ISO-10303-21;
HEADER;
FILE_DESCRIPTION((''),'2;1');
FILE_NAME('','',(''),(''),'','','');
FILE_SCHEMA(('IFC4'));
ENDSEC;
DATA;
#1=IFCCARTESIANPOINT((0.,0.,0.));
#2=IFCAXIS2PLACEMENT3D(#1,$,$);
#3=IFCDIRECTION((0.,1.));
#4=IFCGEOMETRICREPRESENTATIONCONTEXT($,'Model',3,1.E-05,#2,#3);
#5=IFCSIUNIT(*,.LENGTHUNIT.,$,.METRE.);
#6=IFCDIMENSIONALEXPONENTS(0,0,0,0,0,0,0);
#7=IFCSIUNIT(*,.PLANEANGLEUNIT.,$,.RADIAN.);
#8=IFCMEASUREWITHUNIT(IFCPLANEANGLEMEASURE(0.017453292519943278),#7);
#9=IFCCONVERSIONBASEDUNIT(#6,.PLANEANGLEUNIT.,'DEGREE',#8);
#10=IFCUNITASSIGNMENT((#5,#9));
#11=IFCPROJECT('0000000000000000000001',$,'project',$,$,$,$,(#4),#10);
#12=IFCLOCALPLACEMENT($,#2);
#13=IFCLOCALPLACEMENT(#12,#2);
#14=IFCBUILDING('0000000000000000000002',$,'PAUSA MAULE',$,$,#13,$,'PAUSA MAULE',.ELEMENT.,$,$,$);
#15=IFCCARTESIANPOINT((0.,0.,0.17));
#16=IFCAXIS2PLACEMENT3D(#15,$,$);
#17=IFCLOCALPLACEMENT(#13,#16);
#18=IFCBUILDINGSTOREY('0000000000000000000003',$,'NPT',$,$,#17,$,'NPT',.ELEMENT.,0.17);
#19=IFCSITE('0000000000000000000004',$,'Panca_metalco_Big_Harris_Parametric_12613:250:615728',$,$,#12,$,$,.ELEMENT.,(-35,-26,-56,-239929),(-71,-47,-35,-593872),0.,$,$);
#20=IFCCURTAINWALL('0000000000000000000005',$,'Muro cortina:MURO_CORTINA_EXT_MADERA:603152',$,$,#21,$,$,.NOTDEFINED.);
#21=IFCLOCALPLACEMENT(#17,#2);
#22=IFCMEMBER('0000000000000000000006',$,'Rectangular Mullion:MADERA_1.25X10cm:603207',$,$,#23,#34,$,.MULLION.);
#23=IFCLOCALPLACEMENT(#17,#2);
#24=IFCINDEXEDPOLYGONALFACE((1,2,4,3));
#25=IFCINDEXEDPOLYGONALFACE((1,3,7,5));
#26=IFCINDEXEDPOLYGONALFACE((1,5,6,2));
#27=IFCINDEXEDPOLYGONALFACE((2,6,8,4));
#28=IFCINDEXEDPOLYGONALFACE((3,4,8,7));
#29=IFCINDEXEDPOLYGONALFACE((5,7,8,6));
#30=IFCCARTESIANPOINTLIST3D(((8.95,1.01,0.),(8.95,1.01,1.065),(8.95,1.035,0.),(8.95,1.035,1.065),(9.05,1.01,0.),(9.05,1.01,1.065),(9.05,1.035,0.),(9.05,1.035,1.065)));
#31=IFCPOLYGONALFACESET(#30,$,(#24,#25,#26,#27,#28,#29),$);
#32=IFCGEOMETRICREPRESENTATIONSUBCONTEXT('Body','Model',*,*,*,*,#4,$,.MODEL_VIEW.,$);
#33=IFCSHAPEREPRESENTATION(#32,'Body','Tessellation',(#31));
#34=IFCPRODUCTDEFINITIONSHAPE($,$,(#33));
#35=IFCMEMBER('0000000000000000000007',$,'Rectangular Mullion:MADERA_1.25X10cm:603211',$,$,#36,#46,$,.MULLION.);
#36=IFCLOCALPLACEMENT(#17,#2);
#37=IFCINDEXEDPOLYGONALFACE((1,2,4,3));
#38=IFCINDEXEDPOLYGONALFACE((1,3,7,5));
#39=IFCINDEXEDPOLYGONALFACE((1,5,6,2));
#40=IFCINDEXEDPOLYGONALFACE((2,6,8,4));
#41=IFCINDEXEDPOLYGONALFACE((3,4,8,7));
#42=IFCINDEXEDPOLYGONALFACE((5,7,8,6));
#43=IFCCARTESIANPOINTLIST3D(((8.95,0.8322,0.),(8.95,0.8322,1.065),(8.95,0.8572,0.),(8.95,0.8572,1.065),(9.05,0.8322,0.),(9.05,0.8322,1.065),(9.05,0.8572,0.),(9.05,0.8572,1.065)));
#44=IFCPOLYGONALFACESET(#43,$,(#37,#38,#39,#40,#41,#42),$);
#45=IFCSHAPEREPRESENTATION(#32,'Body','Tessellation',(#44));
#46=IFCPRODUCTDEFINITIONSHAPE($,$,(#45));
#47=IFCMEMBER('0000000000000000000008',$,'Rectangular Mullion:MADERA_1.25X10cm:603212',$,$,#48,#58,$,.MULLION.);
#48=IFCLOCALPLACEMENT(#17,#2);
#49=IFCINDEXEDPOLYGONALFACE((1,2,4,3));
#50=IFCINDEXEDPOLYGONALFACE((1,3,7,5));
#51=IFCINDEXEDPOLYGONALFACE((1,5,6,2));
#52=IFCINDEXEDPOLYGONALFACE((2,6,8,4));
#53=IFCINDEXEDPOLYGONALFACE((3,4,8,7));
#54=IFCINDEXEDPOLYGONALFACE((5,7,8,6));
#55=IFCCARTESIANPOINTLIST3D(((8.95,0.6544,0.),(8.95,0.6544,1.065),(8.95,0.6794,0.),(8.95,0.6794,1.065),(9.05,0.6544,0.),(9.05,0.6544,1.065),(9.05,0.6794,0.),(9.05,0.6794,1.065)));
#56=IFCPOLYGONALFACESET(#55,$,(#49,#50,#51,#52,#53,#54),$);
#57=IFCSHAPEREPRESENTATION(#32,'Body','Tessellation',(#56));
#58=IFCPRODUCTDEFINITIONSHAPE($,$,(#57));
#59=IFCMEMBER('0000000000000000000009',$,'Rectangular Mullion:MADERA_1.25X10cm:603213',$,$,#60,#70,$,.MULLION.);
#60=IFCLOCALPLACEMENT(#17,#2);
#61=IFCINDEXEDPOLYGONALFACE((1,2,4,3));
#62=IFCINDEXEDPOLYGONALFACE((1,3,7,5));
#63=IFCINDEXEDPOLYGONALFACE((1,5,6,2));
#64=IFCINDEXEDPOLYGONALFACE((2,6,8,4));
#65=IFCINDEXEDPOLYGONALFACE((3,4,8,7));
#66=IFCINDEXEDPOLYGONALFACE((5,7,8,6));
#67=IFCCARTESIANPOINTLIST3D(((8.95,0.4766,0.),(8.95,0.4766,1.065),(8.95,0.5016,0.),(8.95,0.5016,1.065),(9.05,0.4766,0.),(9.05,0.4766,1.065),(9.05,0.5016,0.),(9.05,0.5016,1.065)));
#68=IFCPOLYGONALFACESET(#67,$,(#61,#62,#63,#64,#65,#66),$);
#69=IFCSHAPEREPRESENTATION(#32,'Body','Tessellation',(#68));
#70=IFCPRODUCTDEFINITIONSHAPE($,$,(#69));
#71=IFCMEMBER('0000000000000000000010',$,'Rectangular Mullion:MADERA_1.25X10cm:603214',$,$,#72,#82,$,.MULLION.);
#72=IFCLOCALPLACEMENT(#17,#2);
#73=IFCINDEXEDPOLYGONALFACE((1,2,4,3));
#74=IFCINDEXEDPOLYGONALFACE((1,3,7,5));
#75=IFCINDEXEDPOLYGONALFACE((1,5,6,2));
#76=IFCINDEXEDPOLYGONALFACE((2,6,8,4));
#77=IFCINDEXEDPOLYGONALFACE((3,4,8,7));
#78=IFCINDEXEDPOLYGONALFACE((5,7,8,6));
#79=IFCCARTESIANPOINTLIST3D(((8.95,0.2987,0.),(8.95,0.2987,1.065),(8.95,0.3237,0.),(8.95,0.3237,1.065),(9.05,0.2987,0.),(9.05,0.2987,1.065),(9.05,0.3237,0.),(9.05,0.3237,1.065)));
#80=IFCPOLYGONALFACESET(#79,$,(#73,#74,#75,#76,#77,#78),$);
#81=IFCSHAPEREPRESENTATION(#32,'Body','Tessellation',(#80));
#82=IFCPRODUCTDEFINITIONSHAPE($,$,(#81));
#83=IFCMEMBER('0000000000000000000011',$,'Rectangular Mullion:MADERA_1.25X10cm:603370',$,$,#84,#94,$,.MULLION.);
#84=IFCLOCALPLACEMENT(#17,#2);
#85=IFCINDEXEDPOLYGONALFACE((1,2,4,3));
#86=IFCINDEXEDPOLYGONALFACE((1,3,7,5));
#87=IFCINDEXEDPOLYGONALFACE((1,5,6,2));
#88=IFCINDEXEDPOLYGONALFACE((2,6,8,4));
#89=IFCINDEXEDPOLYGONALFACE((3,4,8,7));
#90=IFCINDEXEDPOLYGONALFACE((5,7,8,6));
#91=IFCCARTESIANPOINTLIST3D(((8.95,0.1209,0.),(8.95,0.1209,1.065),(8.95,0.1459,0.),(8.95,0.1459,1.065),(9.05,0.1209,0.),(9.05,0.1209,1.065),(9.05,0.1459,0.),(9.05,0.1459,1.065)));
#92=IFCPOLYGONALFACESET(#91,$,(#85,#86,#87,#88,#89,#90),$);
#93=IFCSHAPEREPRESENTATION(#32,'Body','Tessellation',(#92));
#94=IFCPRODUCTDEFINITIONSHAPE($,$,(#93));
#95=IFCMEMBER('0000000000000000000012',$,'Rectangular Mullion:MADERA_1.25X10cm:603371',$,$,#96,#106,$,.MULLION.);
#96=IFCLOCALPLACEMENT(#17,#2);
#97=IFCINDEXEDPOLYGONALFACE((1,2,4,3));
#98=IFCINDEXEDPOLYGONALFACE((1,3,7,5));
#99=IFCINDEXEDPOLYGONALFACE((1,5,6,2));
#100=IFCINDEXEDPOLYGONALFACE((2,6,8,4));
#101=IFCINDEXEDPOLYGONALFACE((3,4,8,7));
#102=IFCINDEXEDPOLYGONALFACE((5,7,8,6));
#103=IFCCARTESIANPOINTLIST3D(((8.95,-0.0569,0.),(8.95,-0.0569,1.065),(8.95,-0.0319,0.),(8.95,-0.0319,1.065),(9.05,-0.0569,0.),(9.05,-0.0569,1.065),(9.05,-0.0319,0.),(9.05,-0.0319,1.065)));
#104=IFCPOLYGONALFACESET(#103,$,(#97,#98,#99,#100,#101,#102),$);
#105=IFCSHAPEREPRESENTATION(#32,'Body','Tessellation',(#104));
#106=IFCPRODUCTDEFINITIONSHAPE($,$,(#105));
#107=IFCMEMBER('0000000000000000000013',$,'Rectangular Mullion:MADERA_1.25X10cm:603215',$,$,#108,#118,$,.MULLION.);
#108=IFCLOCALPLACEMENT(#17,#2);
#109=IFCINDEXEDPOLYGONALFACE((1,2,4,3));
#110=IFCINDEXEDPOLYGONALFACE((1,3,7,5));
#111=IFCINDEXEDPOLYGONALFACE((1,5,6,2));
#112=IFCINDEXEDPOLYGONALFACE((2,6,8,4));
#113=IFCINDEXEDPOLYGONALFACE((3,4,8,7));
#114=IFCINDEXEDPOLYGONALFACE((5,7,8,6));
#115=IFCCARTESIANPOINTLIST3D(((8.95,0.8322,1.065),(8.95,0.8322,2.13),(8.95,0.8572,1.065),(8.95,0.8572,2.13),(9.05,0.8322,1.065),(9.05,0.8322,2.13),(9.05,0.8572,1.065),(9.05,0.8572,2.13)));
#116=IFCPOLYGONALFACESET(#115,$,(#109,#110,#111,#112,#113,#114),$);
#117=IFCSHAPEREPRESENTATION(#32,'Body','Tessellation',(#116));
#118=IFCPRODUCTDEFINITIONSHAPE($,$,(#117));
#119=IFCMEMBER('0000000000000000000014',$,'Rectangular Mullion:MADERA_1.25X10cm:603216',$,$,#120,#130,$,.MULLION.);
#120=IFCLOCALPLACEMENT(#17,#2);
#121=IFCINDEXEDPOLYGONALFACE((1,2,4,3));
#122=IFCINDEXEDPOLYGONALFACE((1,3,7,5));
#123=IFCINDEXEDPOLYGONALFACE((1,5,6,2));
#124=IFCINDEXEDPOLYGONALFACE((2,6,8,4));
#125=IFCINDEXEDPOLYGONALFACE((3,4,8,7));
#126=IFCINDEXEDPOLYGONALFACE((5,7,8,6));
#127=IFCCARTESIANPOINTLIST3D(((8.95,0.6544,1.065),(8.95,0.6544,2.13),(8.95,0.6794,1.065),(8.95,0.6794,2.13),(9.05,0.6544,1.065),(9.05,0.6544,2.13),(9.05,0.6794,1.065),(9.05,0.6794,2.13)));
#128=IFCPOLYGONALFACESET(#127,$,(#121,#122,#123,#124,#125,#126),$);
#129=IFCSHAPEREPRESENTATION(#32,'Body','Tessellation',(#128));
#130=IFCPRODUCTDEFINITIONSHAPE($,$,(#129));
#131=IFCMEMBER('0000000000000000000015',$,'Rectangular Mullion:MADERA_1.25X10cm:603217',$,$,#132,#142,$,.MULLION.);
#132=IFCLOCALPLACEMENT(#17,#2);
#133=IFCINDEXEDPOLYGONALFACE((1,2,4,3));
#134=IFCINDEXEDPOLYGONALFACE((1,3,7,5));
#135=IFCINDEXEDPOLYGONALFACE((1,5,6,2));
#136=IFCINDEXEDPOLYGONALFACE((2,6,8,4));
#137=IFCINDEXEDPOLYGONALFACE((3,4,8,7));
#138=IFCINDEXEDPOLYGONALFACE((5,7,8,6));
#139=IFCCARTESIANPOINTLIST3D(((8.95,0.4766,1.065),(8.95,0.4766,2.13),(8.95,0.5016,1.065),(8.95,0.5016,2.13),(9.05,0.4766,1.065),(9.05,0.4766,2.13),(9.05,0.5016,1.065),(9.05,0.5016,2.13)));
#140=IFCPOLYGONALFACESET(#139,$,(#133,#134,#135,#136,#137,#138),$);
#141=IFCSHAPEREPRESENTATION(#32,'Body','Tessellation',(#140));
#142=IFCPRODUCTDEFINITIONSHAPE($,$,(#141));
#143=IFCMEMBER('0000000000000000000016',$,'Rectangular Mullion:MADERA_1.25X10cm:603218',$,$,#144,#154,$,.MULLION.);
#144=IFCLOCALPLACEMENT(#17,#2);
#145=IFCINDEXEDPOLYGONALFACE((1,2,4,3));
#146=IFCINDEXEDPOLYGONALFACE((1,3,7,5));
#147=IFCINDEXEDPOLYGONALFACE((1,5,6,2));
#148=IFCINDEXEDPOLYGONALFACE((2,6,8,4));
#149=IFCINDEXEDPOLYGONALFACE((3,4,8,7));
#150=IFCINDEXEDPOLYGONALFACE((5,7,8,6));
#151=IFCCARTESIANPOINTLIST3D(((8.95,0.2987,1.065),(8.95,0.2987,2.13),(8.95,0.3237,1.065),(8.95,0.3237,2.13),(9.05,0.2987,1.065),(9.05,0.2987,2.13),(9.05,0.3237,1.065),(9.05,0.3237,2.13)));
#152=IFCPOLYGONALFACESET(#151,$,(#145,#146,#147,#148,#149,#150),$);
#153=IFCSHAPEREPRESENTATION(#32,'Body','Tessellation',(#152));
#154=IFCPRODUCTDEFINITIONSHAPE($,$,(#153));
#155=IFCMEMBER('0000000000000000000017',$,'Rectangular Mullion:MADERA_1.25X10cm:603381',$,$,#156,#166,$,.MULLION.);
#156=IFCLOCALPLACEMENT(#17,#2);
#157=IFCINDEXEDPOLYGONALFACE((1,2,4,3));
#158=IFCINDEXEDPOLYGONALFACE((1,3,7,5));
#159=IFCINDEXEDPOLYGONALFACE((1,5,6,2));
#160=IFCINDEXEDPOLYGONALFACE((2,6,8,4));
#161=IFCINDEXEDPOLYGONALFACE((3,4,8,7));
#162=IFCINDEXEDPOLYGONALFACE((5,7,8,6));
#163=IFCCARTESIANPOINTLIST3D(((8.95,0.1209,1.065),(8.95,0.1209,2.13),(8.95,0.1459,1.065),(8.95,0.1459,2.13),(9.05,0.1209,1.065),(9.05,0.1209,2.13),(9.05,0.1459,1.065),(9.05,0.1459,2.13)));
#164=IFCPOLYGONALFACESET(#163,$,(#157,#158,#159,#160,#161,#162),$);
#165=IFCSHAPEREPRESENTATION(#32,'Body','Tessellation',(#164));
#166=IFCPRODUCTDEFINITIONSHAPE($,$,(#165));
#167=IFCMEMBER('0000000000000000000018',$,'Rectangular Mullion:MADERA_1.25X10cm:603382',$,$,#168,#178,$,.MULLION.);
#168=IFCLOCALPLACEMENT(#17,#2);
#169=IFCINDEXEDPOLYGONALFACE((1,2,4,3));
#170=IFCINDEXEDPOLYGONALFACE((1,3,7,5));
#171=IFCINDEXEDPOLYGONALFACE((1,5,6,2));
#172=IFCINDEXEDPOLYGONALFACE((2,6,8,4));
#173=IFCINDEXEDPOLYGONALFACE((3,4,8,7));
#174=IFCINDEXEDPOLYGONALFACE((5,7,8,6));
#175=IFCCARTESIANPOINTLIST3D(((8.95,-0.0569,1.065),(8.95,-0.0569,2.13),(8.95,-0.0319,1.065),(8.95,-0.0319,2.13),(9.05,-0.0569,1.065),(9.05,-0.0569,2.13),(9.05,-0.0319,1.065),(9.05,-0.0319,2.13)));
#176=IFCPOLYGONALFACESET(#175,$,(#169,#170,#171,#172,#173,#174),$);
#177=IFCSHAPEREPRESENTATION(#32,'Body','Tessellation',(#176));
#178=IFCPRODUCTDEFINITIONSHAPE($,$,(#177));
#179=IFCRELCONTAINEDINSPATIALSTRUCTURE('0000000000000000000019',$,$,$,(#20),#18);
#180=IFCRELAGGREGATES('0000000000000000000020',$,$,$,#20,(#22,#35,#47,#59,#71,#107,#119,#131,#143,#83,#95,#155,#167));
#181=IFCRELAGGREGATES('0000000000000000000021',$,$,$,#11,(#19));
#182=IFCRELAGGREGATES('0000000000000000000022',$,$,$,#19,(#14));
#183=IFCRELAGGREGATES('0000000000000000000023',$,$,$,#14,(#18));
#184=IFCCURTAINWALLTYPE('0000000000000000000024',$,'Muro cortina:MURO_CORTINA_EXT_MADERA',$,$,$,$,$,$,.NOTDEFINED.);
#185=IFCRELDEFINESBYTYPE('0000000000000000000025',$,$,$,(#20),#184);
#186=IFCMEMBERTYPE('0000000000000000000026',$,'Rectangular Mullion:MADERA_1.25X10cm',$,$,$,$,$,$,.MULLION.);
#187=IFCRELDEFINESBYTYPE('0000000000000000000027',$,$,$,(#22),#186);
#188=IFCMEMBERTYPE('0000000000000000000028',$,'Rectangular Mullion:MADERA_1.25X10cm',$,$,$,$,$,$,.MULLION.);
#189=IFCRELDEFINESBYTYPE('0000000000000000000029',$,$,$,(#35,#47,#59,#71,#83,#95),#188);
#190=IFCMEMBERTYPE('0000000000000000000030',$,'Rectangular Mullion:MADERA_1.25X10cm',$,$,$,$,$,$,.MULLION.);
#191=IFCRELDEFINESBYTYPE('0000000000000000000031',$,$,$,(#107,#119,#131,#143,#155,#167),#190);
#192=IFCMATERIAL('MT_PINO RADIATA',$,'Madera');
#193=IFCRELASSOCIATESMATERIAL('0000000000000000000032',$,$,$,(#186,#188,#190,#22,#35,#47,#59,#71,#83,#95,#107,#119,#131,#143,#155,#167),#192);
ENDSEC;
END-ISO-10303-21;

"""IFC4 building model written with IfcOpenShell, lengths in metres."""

from ifc_helpers import new_model, entity, si_unit, converted_unit, direction, frame, frame_2d, origin, place, context, subcontext, project, spatial, rectangle, extrude, source, transform, mapped, material, material_profile, profile_set, profile_usage, type_object, type_shapes, element, aggregate, save


model = new_model("IFC4")

# Units and contexts
model_context = context("Model", 3, precision=1e-05, world=origin(), true_north=direction((0.0, 1.0)))
body_context = subcontext(model_context, "Body", "Model", "MODEL_VIEW")
ifc_project = project(units=[si_unit("LENGTHUNIT", "METRE"), converted_unit("PLANEANGLEUNIT", "DEGREE", entity("IfcPlaneAngleMeasure", 0.017453292519943278), si_unit("PLANEANGLEUNIT", "RADIAN"), dimensions=[0, 0, 0, 0, 0, 0, 0])], contexts=[model_context])

# Site, building, storey
site_placement = place(None, origin())
site = spatial("IfcSite", under=ifc_project, at=site_placement, Name="Panca_metalco_Big_Harris_Parametric_12613:250:615728", CompositionType="ELEMENT", RefLatitude=(-35, -26, -56, -239929), RefLongitude=(-71, -47, -35, -593872), RefElevation=0.0)
building_placement = place(site_placement, origin())
building = spatial("IfcBuilding", under=site, at=building_placement, Name="PAUSA MAULE", LongName="PAUSA MAULE", CompositionType="ELEMENT")
storey_placement = place(building_placement, frame((0.0, 0.0, 0.17)))
storey = spatial("IfcBuildingStorey", under=building, at=storey_placement, Name="NPT", LongName="NPT", CompositionType="ELEMENT", Elevation=0.17)

# Curtain wall, members
curtain_wall_type = type_object("IfcCurtainWallType", Name="Muro cortina:MURO_CORTINA_EXT_MADERA", PredefinedType="NOTDEFINED")
curtain_wall_placement = place(storey_placement, frame((0.0, 0.0, -0.17)))
curtain_wall = element("IfcCurtainWall", 1, at=curtain_wall_placement, inside=storey, type_object=curtain_wall_type, Name="Muro cortina:MURO_CORTINA_EXT_MADERA:603152", PredefinedType="NOTDEFINED")
ifc_material = material(Name="MT_PINO RADIATA", Category="Madera")
ifc_material_profile = material_profile(ifc_material, rectangle(XDim=0.025, YDim=0.1, at=frame_2d((0.0, 0.0), x_axis=(1.0, 0.0))), Name="MADERA_1.25X10cm")
ifc_profile_set = profile_set([ifc_material_profile], Name="MADERA_1.25X10cm")
ifc_profile_usage = profile_usage(ifc_profile_set)
member_type_1 = type_object("IfcMemberType", Name="Rectangular Mullion:MADERA_1.25X10cm", PredefinedType="MULLION", material=ifc_profile_set)
shared_shape_1 = source(origin(), body_context, "Body", "SweptSolid", [
    extrude(rectangle(XDim=0.025, YDim=0.1, at=frame_2d((0.0, 0.0), x_axis=(1.0, 0.0))), frame((-0.0125, 0.0, -1.065), z_axis=(0.0, 0.0, 1.0), x_axis=(-1.0, 0.0, 0.0)), (0.0, 0.0, 1.0), 1.065),
])
type_shapes(member_type_1, [shared_shape_1])
member_1_placement = place(curtain_wall_placement, frame((9.0, 1.035, 1.235), z_axis=(0.0, 0.0, 1.0), x_axis=(0.0, 1.0, 0.0)))
member_1 = element("IfcMember", 2, at=member_1_placement, type_object=member_type_1, material=ifc_profile_usage, Name="Rectangular Mullion:MADERA_1.25X10cm:603207", PredefinedType="MULLION", context=body_context, shape_type="MappedRepresentation", body=[
    mapped(shared_shape_1, transform((0.0, 0.0, 0.0), scale=1.0)),
])
member_type_2 = type_object("IfcMemberType", Name="Rectangular Mullion:MADERA_1.25X10cm", PredefinedType="MULLION", material=ifc_profile_set)
shared_shape_2 = source(origin(), body_context, "Body", "SweptSolid", [
    extrude(rectangle(XDim=0.025, YDim=0.1, at=frame_2d((0.0, 0.0), x_axis=(1.0, 0.0))), frame((0.0, 0.0, -1.065), z_axis=(0.0, 0.0, 1.0), x_axis=(-1.0, 0.0, 0.0)), (0.0, 0.0, 1.0), 1.065),
])
type_shapes(member_type_2, [shared_shape_2])
member_2_placement = place(curtain_wall_placement, frame((9.0, 0.8447, 0.17), z_axis=(0.0, 0.0, -1.0), x_axis=(0.0, -1.0, 0.0)))
member_2 = element("IfcMember", 3, at=member_2_placement, type_object=member_type_2, material=ifc_profile_usage, Name="Rectangular Mullion:MADERA_1.25X10cm:603211", PredefinedType="MULLION", context=body_context, shape_type="MappedRepresentation", body=[
    mapped(shared_shape_2, transform((0.0, 0.0, 0.0), scale=1.0)),
])
member_3_placement = place(curtain_wall_placement, frame((9.0, 0.6669, 0.17), z_axis=(0.0, 0.0, -1.0), x_axis=(0.0, -1.0, 0.0)))
member_3 = element("IfcMember", 4, at=member_3_placement, type_object=member_type_2, material=ifc_profile_usage, Name="Rectangular Mullion:MADERA_1.25X10cm:603212", PredefinedType="MULLION", context=body_context, shape_type="MappedRepresentation", body=[
    mapped(shared_shape_2, transform((0.0, 0.0, 0.0), scale=1.0)),
])
member_4_placement = place(curtain_wall_placement, frame((9.0, 0.4891, 0.17), z_axis=(0.0, 0.0, -1.0), x_axis=(0.0, -1.0, 0.0)))
member_4 = element("IfcMember", 5, at=member_4_placement, type_object=member_type_2, material=ifc_profile_usage, Name="Rectangular Mullion:MADERA_1.25X10cm:603213", PredefinedType="MULLION", context=body_context, shape_type="MappedRepresentation", body=[
    mapped(shared_shape_2, transform((0.0, 0.0, 0.0), scale=1.0)),
])
member_5_placement = place(curtain_wall_placement, frame((9.0, 0.3112, 0.17), z_axis=(0.0, 0.0, -1.0), x_axis=(0.0, -1.0, 0.0)))
member_5 = element("IfcMember", 6, at=member_5_placement, type_object=member_type_2, material=ifc_profile_usage, Name="Rectangular Mullion:MADERA_1.25X10cm:603214", PredefinedType="MULLION", context=body_context, shape_type="MappedRepresentation", body=[
    mapped(shared_shape_2, transform((0.0, 0.0, 0.0), scale=1.0)),
])
member_6_placement = place(curtain_wall_placement, frame((9.0, 0.1334, 0.17), z_axis=(0.0, 0.0, -1.0), x_axis=(0.0, -1.0, 0.0)))
member_6 = element("IfcMember", 7, at=member_6_placement, type_object=member_type_2, material=ifc_profile_usage, Name="Rectangular Mullion:MADERA_1.25X10cm:603370", PredefinedType="MULLION", context=body_context, shape_type="MappedRepresentation", body=[
    mapped(shared_shape_2, transform((0.0, 0.0, 0.0), scale=1.0)),
])
member_7_placement = place(curtain_wall_placement, frame((9.0, -0.0444, 0.17), z_axis=(0.0, 0.0, -1.0), x_axis=(0.0, -1.0, 0.0)))
member_7 = element("IfcMember", 8, at=member_7_placement, type_object=member_type_2, material=ifc_profile_usage, Name="Rectangular Mullion:MADERA_1.25X10cm:603371", PredefinedType="MULLION", context=body_context, shape_type="MappedRepresentation", body=[
    mapped(shared_shape_2, transform((0.0, 0.0, 0.0), scale=1.0)),
])
member_type_3 = type_object("IfcMemberType", Name="Rectangular Mullion:MADERA_1.25X10cm", PredefinedType="MULLION", material=ifc_profile_set)
shared_shape_3 = source(origin(), body_context, "Body", "SweptSolid", [
    extrude(rectangle(XDim=0.025, YDim=0.1, at=frame_2d((0.0, 0.0), x_axis=(1.0, 0.0))), frame((0.0, 0.0, -1.065), z_axis=(0.0, 0.0, 1.0), x_axis=(-1.0, 0.0, 0.0)), (0.0, 0.0, 1.0), 1.065),
])
type_shapes(member_type_3, [shared_shape_3])
member_8_placement = place(curtain_wall_placement, frame((9.0, 0.8447, 1.235), z_axis=(0.0, 0.0, -1.0), x_axis=(0.0, -1.0, 0.0)))
member_8 = element("IfcMember", 9, at=member_8_placement, type_object=member_type_3, material=ifc_profile_usage, Name="Rectangular Mullion:MADERA_1.25X10cm:603215", PredefinedType="MULLION", context=body_context, shape_type="MappedRepresentation", body=[
    mapped(shared_shape_3, transform((0.0, 0.0, 0.0), scale=1.0)),
])
member_9_placement = place(curtain_wall_placement, frame((9.0, 0.6669, 1.235), z_axis=(0.0, 0.0, -1.0), x_axis=(0.0, -1.0, 0.0)))
member_9 = element("IfcMember", 10, at=member_9_placement, type_object=member_type_3, material=ifc_profile_usage, Name="Rectangular Mullion:MADERA_1.25X10cm:603216", PredefinedType="MULLION", context=body_context, shape_type="MappedRepresentation", body=[
    mapped(shared_shape_3, transform((0.0, 0.0, 0.0), scale=1.0)),
])
member_10_placement = place(curtain_wall_placement, frame((9.0, 0.4891, 1.235), z_axis=(0.0, 0.0, -1.0), x_axis=(0.0, -1.0, 0.0)))
member_10 = element("IfcMember", 11, at=member_10_placement, type_object=member_type_3, material=ifc_profile_usage, Name="Rectangular Mullion:MADERA_1.25X10cm:603217", PredefinedType="MULLION", context=body_context, shape_type="MappedRepresentation", body=[
    mapped(shared_shape_3, transform((0.0, 0.0, 0.0), scale=1.0)),
])
member_11_placement = place(curtain_wall_placement, frame((9.0, 0.3112, 1.235), z_axis=(0.0, 0.0, -1.0), x_axis=(0.0, -1.0, 0.0)))
member_11 = element("IfcMember", 12, at=member_11_placement, type_object=member_type_3, material=ifc_profile_usage, Name="Rectangular Mullion:MADERA_1.25X10cm:603218", PredefinedType="MULLION", context=body_context, shape_type="MappedRepresentation", body=[
    mapped(shared_shape_3, transform((0.0, 0.0, 0.0), scale=1.0)),
])
member_12_placement = place(curtain_wall_placement, frame((9.0, 0.1334, 1.235), z_axis=(0.0, 0.0, -1.0), x_axis=(0.0, -1.0, 0.0)))
member_12 = element("IfcMember", 13, at=member_12_placement, type_object=member_type_3, material=ifc_profile_usage, Name="Rectangular Mullion:MADERA_1.25X10cm:603381", PredefinedType="MULLION", context=body_context, shape_type="MappedRepresentation", body=[
    mapped(shared_shape_3, transform((0.0, 0.0, 0.0), scale=1.0)),
])
member_13_placement = place(curtain_wall_placement, frame((9.0, -0.0444, 1.235), z_axis=(0.0, 0.0, -1.0), x_axis=(0.0, -1.0, 0.0)))
member_13 = element("IfcMember", 14, at=member_13_placement, type_object=member_type_3, material=ifc_profile_usage, Name="Rectangular Mullion:MADERA_1.25X10cm:603382", PredefinedType="MULLION", context=body_context, shape_type="MappedRepresentation", body=[
    mapped(shared_shape_3, transform((0.0, 0.0, 0.0), scale=1.0)),
])
aggregate(curtain_wall, [member_1, member_2, member_3, member_4, member_5, member_8, member_9, member_10, member_11, member_6, member_7, member_12, member_13])

save(model, "model.ifc")
